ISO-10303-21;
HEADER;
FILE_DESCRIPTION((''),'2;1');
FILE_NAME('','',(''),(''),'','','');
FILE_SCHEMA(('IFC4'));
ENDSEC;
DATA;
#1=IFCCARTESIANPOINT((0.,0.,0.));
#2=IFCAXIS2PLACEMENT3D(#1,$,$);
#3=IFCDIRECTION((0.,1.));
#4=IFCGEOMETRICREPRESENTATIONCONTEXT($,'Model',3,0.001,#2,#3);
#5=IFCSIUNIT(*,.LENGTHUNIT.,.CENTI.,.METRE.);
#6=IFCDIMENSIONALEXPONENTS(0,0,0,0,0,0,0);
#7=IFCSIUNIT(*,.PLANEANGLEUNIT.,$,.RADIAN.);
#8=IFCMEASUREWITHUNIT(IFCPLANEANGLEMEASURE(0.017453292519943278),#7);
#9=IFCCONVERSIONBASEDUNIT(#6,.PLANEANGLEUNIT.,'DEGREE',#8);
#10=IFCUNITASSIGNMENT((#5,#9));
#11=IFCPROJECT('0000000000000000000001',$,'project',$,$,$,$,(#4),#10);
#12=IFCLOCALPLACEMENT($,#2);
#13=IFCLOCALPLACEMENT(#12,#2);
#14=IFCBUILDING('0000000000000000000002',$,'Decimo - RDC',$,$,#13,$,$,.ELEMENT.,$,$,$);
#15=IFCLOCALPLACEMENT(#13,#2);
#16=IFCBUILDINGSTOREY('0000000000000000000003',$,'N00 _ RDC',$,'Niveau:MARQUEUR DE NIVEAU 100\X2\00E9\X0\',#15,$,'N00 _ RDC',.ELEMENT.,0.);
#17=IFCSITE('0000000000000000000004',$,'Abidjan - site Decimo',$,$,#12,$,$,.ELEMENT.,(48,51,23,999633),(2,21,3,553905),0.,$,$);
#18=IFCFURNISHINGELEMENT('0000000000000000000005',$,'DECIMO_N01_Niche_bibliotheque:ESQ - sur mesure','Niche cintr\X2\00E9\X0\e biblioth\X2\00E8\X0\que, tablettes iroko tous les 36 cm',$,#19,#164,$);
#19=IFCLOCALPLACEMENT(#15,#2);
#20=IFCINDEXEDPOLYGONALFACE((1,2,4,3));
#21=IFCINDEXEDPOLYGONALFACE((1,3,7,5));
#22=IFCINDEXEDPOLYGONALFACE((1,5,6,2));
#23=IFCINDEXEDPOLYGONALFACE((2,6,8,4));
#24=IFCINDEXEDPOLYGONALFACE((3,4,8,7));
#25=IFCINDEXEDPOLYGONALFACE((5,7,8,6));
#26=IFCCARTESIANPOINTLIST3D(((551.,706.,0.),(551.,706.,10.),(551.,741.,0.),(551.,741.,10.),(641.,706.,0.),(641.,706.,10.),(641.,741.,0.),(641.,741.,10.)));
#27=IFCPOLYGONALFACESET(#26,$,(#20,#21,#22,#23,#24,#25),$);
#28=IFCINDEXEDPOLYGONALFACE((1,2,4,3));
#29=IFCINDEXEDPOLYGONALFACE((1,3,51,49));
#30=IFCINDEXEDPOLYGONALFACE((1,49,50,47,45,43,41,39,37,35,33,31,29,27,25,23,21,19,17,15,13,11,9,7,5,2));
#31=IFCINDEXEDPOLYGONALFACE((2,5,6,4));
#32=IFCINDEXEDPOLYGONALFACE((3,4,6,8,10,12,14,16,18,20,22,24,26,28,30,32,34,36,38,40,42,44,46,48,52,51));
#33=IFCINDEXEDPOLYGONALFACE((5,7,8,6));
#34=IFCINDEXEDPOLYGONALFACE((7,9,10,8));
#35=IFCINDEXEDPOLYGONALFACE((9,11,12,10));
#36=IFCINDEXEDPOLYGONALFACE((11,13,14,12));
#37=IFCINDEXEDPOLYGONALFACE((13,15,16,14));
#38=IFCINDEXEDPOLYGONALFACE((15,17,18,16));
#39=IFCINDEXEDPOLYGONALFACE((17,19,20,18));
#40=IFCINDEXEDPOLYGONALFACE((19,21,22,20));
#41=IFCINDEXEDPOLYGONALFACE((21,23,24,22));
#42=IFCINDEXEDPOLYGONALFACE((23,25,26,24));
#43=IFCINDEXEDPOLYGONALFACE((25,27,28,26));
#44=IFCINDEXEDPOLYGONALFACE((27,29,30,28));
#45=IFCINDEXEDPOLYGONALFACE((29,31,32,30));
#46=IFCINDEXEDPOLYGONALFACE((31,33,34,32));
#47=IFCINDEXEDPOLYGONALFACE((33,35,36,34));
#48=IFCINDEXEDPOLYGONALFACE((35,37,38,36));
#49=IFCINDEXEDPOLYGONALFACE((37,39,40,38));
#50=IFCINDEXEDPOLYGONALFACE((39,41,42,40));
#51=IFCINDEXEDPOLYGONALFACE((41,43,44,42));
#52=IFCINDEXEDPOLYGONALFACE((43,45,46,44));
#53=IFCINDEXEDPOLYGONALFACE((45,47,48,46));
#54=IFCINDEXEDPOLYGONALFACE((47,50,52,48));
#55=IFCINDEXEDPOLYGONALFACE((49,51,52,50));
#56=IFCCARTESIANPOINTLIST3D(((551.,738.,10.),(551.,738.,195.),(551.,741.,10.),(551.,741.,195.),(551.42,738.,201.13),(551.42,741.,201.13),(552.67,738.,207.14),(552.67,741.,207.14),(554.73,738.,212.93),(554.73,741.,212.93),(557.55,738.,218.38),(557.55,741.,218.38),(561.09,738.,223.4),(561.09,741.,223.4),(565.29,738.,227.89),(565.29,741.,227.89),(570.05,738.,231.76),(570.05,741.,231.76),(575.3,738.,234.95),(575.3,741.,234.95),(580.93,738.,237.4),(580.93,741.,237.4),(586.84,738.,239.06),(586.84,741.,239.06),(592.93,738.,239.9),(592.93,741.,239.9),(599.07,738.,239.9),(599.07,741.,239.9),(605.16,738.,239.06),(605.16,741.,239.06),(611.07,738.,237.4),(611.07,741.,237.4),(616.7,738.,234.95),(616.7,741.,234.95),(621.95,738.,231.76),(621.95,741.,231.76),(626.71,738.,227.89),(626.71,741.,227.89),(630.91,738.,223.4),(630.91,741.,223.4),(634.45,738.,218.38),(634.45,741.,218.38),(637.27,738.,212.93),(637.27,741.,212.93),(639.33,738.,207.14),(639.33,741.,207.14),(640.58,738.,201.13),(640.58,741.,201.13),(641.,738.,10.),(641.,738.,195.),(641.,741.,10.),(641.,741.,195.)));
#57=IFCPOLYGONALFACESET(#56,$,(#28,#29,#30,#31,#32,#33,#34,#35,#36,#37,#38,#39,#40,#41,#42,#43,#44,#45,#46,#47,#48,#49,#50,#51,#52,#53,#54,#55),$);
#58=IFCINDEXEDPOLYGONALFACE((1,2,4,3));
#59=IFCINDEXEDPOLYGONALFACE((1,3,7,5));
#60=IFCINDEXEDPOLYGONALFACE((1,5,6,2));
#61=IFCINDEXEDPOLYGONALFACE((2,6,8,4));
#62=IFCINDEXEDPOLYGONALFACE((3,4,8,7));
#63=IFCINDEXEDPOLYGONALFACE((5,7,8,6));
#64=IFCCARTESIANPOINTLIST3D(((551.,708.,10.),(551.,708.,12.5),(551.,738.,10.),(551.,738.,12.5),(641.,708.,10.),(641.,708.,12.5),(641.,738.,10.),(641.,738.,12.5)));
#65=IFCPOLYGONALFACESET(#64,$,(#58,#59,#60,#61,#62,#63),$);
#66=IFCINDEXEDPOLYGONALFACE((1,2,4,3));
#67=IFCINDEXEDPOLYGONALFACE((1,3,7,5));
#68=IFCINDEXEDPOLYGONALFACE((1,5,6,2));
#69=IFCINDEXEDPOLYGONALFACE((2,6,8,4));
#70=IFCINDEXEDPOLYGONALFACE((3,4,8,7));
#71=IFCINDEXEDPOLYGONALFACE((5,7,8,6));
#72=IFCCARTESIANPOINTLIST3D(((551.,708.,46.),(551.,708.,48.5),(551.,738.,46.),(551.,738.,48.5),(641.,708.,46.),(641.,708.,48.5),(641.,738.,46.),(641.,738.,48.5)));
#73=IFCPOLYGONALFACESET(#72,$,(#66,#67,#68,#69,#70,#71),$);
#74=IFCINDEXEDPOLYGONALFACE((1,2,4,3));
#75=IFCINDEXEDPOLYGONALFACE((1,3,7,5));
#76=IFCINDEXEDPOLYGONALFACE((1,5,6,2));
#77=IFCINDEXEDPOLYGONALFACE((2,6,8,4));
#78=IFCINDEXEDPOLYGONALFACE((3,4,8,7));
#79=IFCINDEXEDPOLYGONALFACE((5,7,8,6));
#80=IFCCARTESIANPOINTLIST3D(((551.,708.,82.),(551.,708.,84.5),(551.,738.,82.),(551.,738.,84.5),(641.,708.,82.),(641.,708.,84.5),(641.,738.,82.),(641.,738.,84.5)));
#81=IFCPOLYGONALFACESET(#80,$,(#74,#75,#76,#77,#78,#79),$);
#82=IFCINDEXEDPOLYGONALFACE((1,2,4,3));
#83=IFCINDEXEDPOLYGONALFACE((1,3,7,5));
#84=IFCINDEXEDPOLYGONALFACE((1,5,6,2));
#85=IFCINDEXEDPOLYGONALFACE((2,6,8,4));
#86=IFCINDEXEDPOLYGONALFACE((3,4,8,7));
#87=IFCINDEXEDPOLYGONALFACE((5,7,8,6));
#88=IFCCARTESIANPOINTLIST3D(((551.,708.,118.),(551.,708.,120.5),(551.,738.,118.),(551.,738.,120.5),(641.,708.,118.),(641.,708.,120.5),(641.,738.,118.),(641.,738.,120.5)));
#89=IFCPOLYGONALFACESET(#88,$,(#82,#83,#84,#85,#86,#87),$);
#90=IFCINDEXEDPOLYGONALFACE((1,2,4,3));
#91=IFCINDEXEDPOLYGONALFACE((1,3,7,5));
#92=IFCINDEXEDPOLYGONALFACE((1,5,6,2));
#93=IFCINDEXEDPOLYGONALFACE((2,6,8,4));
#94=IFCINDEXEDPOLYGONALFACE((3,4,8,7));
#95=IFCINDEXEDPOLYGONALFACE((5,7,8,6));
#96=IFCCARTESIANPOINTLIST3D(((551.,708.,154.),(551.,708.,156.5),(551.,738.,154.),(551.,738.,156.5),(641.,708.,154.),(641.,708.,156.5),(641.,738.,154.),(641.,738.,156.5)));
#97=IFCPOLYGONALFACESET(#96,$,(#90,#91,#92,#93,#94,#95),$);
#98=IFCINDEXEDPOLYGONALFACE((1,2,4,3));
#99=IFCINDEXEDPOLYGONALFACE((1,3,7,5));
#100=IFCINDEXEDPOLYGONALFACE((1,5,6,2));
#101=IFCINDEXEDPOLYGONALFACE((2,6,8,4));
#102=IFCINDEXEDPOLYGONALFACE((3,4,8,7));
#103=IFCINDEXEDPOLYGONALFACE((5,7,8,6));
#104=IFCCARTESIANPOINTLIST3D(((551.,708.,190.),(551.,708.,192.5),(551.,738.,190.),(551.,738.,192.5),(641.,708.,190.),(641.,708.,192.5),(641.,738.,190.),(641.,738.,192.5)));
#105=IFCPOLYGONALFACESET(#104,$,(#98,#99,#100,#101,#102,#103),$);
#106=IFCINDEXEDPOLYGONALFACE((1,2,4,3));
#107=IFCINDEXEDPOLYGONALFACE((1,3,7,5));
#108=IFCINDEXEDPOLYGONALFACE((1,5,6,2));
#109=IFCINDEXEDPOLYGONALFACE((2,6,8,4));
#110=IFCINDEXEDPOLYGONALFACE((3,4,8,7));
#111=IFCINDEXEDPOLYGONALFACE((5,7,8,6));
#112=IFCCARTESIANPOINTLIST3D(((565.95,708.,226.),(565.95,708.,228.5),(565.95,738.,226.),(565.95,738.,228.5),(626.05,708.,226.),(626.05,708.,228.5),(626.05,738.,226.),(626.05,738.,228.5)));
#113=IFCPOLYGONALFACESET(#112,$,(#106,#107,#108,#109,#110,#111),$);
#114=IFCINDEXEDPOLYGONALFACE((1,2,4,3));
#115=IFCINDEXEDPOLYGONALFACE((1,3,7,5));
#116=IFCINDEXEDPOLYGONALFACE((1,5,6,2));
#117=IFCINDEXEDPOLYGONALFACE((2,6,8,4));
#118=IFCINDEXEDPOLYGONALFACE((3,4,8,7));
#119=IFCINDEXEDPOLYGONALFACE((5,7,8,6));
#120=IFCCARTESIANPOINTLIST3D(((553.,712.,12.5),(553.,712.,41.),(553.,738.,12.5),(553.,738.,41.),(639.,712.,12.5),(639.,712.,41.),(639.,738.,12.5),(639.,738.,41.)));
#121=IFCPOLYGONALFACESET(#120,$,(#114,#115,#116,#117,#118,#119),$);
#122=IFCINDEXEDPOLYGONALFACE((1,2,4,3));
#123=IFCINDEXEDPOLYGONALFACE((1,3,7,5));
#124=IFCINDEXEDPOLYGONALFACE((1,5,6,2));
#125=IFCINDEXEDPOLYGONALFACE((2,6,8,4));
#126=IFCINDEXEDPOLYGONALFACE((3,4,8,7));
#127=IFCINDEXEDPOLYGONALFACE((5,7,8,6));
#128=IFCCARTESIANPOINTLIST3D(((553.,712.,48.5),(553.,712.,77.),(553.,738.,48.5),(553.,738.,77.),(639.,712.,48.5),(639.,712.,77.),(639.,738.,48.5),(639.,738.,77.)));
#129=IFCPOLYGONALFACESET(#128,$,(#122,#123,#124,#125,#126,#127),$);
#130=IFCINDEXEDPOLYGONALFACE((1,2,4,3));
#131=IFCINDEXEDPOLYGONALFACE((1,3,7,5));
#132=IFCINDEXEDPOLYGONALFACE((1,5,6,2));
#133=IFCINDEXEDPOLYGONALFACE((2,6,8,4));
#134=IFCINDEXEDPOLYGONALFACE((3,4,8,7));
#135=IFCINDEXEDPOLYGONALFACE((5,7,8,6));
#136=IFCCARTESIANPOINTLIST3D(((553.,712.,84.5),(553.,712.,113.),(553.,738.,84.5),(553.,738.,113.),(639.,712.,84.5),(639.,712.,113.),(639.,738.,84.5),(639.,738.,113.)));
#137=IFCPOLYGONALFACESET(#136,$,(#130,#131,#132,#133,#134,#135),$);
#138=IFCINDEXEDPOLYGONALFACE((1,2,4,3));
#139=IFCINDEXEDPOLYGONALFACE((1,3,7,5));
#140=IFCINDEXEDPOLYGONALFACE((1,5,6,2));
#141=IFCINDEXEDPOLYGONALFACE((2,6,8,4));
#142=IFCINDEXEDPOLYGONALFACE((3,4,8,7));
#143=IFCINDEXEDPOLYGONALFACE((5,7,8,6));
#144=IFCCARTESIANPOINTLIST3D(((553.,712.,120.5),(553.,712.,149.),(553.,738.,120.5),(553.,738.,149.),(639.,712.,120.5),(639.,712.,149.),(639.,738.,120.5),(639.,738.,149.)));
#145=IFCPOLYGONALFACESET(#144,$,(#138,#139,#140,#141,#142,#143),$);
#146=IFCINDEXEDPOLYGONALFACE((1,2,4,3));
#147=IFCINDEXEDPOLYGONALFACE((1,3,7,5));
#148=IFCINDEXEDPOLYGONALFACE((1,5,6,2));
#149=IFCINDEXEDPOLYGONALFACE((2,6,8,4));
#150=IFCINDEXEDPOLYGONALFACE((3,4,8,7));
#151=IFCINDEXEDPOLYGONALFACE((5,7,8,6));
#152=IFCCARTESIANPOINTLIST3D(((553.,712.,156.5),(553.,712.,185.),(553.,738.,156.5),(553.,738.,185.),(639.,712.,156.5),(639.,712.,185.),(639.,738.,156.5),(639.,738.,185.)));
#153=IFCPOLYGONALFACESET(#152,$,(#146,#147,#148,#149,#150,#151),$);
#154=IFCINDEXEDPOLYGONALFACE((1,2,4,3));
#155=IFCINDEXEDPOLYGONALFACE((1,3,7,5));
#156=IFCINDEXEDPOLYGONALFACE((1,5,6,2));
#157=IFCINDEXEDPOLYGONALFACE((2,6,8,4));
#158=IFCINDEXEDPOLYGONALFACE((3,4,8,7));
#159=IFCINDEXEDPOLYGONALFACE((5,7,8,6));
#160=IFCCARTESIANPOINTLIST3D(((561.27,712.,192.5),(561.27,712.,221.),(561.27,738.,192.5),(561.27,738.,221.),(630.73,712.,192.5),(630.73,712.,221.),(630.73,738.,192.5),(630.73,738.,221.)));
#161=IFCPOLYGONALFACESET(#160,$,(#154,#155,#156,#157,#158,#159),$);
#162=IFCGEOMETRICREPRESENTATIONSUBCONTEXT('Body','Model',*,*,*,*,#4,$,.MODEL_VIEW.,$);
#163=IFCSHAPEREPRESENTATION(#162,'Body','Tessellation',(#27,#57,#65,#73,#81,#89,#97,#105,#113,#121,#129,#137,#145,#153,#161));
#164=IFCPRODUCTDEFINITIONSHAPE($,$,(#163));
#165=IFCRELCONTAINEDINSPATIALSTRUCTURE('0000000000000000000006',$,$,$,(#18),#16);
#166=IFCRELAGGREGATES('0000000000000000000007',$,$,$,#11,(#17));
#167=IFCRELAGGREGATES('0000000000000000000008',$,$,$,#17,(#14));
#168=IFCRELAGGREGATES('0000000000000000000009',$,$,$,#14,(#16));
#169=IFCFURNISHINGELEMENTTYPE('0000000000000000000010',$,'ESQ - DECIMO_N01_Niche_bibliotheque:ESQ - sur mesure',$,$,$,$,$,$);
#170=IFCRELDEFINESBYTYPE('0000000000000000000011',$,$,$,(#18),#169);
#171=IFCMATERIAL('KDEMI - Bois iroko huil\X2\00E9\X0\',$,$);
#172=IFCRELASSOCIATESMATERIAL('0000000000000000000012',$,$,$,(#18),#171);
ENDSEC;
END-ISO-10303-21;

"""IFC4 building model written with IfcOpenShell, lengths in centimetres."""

from ifc_helpers import new_model, entity, si_unit, converted_unit, direction, frame, frame_2d, origin, origin_with_axes, place, context, subcontext, project, spatial, polyline, rectangle, outline, extrude, material, type_object, element, save


model = new_model("IFC4")

# Units and contexts
model_context = context("Model", 3, precision=0.001, world=origin(), true_north=direction((0.0, 1.0)))
body_context = subcontext(model_context, "Body", "Model", "MODEL_VIEW")
ifc_project = project(units=[si_unit("LENGTHUNIT", "METRE", prefix="CENTI"), converted_unit("PLANEANGLEUNIT", "DEGREE", entity("IfcPlaneAngleMeasure", 0.017453292519943278), si_unit("PLANEANGLEUNIT", "RADIAN"), dimensions=[0, 0, 0, 0, 0, 0, 0])], contexts=[model_context])

# Site, building, storey
site_placement = place(None, origin())
site = spatial("IfcSite", under=ifc_project, at=site_placement, Name="Abidjan - site Decimo", CompositionType="ELEMENT", RefLatitude=(48, 51, 23, 999633), RefLongitude=(2, 21, 3, 553905), RefElevation=0.0)
building_placement = place(site_placement, origin())
building = spatial("IfcBuilding", under=site, at=building_placement, Name="Decimo - RDC", CompositionType="ELEMENT")
storey_placement = place(building_placement, origin())
storey = spatial("IfcBuildingStorey", under=building, at=storey_placement, Name="N00 _ RDC", ObjectType="Niveau:MARQUEUR DE NIVEAU 100é", LongName="N00 _ RDC", CompositionType="ELEMENT", Elevation=0.0)

# Furnishing element
ifc_material_1 = material(Name="KDEMI - Bois iroko huilé")
furnishing_element_type_1 = type_object("IfcFurnishingElementType", Name="ESQ - DECIMO_N01_Niche_bibliotheque:ESQ - sur mesure")
furnishing_1_placement = place(storey_placement, origin_with_axes())
element("IfcFurnishingElement", 1, at=furnishing_1_placement, inside=storey, type_object=furnishing_element_type_1, material=ifc_material_1, Name="DECIMO_N01_Niche_bibliotheque:ESQ - sur mesure", Description="Niche cintrée bibliothèque, tablettes iroko tous les 36 cm", context=body_context, shape_type="SweptSolid", body=[
    extrude(rectangle(XDim=90.0, YDim=35.0, at=frame_2d((596.0, 723.5))), origin(), (0.0, 0.0, 1.0), 10.0),
    extrude(outline(polyline([(551.0, 10.0), (641.0, 10.0), (641.0, 195.0), (640.58, 201.13), (639.33, 207.14), (637.27, 212.93), (634.45, 218.38), (630.91, 223.4), (626.71, 227.89), (621.95, 231.76), (616.7, 234.95), (611.07, 237.4), (605.16, 239.06), (599.07, 239.9), (592.93, 239.9), (586.84, 239.06), (580.93, 237.4), (575.3, 234.95), (570.05, 231.76), (565.29, 227.89), (561.09, 223.4), (557.55, 218.38), (554.73, 212.93), (552.67, 207.14), (551.42, 201.13), (551.0, 195.0), (551.0, 10.0)])), frame((0.0, 741.0, 0.0), z_axis=(0.0, -1.0, 0.0), x_axis=(1.0, 0.0, 0.0)), (0.0, 0.0, 1.0), 3.0),
    extrude(rectangle(XDim=90.0, YDim=30.0, at=frame_2d((596.0, 723.0))), frame((0.0, 0.0, 10.0)), (0.0, 0.0, 1.0), 2.5),
    extrude(rectangle(XDim=90.0, YDim=30.0, at=frame_2d((596.0, 723.0))), frame((0.0, 0.0, 46.0)), (0.0, 0.0, 1.0), 2.5),
    extrude(rectangle(XDim=90.0, YDim=30.0, at=frame_2d((596.0, 723.0))), frame((0.0, 0.0, 82.0)), (0.0, 0.0, 1.0), 2.5),
    extrude(rectangle(XDim=90.0, YDim=30.0, at=frame_2d((596.0, 723.0))), frame((0.0, 0.0, 118.0)), (0.0, 0.0, 1.0), 2.5),
    extrude(rectangle(XDim=90.0, YDim=30.0, at=frame_2d((596.0, 723.0))), frame((0.0, 0.0, 154.0)), (0.0, 0.0, 1.0), 2.5),
    extrude(rectangle(XDim=90.0, YDim=30.0, at=frame_2d((596.0, 723.0))), frame((0.0, 0.0, 190.0)), (0.0, 0.0, 1.0), 2.5),
    extrude(rectangle(XDim=60.09, YDim=30.0, at=frame_2d((596.0, 723.0))), frame((0.0, 0.0, 226.0)), (0.0, 0.0, 1.0), 2.5),
    extrude(rectangle(XDim=86.0, YDim=26.0, at=frame_2d((596.0, 725.0))), frame((0.0, 0.0, 12.5)), (0.0, 0.0, 1.0), 28.5),
    extrude(rectangle(XDim=86.0, YDim=26.0, at=frame_2d((596.0, 725.0))), frame((0.0, 0.0, 48.5)), (0.0, 0.0, 1.0), 28.5),
    extrude(rectangle(XDim=86.0, YDim=26.0, at=frame_2d((596.0, 725.0))), frame((0.0, 0.0, 84.5)), (0.0, 0.0, 1.0), 28.5),
    extrude(rectangle(XDim=86.0, YDim=26.0, at=frame_2d((596.0, 725.0))), frame((0.0, 0.0, 120.5)), (0.0, 0.0, 1.0), 28.5),
    extrude(rectangle(XDim=86.0, YDim=26.0, at=frame_2d((596.0, 725.0))), frame((0.0, 0.0, 156.5)), (0.0, 0.0, 1.0), 28.5),
    extrude(rectangle(XDim=69.46, YDim=26.0, at=frame_2d((596.0, 725.0))), frame((0.0, 0.0, 192.5)), (0.0, 0.0, 1.0), 28.5),
])

save(model, "model.ifc")
